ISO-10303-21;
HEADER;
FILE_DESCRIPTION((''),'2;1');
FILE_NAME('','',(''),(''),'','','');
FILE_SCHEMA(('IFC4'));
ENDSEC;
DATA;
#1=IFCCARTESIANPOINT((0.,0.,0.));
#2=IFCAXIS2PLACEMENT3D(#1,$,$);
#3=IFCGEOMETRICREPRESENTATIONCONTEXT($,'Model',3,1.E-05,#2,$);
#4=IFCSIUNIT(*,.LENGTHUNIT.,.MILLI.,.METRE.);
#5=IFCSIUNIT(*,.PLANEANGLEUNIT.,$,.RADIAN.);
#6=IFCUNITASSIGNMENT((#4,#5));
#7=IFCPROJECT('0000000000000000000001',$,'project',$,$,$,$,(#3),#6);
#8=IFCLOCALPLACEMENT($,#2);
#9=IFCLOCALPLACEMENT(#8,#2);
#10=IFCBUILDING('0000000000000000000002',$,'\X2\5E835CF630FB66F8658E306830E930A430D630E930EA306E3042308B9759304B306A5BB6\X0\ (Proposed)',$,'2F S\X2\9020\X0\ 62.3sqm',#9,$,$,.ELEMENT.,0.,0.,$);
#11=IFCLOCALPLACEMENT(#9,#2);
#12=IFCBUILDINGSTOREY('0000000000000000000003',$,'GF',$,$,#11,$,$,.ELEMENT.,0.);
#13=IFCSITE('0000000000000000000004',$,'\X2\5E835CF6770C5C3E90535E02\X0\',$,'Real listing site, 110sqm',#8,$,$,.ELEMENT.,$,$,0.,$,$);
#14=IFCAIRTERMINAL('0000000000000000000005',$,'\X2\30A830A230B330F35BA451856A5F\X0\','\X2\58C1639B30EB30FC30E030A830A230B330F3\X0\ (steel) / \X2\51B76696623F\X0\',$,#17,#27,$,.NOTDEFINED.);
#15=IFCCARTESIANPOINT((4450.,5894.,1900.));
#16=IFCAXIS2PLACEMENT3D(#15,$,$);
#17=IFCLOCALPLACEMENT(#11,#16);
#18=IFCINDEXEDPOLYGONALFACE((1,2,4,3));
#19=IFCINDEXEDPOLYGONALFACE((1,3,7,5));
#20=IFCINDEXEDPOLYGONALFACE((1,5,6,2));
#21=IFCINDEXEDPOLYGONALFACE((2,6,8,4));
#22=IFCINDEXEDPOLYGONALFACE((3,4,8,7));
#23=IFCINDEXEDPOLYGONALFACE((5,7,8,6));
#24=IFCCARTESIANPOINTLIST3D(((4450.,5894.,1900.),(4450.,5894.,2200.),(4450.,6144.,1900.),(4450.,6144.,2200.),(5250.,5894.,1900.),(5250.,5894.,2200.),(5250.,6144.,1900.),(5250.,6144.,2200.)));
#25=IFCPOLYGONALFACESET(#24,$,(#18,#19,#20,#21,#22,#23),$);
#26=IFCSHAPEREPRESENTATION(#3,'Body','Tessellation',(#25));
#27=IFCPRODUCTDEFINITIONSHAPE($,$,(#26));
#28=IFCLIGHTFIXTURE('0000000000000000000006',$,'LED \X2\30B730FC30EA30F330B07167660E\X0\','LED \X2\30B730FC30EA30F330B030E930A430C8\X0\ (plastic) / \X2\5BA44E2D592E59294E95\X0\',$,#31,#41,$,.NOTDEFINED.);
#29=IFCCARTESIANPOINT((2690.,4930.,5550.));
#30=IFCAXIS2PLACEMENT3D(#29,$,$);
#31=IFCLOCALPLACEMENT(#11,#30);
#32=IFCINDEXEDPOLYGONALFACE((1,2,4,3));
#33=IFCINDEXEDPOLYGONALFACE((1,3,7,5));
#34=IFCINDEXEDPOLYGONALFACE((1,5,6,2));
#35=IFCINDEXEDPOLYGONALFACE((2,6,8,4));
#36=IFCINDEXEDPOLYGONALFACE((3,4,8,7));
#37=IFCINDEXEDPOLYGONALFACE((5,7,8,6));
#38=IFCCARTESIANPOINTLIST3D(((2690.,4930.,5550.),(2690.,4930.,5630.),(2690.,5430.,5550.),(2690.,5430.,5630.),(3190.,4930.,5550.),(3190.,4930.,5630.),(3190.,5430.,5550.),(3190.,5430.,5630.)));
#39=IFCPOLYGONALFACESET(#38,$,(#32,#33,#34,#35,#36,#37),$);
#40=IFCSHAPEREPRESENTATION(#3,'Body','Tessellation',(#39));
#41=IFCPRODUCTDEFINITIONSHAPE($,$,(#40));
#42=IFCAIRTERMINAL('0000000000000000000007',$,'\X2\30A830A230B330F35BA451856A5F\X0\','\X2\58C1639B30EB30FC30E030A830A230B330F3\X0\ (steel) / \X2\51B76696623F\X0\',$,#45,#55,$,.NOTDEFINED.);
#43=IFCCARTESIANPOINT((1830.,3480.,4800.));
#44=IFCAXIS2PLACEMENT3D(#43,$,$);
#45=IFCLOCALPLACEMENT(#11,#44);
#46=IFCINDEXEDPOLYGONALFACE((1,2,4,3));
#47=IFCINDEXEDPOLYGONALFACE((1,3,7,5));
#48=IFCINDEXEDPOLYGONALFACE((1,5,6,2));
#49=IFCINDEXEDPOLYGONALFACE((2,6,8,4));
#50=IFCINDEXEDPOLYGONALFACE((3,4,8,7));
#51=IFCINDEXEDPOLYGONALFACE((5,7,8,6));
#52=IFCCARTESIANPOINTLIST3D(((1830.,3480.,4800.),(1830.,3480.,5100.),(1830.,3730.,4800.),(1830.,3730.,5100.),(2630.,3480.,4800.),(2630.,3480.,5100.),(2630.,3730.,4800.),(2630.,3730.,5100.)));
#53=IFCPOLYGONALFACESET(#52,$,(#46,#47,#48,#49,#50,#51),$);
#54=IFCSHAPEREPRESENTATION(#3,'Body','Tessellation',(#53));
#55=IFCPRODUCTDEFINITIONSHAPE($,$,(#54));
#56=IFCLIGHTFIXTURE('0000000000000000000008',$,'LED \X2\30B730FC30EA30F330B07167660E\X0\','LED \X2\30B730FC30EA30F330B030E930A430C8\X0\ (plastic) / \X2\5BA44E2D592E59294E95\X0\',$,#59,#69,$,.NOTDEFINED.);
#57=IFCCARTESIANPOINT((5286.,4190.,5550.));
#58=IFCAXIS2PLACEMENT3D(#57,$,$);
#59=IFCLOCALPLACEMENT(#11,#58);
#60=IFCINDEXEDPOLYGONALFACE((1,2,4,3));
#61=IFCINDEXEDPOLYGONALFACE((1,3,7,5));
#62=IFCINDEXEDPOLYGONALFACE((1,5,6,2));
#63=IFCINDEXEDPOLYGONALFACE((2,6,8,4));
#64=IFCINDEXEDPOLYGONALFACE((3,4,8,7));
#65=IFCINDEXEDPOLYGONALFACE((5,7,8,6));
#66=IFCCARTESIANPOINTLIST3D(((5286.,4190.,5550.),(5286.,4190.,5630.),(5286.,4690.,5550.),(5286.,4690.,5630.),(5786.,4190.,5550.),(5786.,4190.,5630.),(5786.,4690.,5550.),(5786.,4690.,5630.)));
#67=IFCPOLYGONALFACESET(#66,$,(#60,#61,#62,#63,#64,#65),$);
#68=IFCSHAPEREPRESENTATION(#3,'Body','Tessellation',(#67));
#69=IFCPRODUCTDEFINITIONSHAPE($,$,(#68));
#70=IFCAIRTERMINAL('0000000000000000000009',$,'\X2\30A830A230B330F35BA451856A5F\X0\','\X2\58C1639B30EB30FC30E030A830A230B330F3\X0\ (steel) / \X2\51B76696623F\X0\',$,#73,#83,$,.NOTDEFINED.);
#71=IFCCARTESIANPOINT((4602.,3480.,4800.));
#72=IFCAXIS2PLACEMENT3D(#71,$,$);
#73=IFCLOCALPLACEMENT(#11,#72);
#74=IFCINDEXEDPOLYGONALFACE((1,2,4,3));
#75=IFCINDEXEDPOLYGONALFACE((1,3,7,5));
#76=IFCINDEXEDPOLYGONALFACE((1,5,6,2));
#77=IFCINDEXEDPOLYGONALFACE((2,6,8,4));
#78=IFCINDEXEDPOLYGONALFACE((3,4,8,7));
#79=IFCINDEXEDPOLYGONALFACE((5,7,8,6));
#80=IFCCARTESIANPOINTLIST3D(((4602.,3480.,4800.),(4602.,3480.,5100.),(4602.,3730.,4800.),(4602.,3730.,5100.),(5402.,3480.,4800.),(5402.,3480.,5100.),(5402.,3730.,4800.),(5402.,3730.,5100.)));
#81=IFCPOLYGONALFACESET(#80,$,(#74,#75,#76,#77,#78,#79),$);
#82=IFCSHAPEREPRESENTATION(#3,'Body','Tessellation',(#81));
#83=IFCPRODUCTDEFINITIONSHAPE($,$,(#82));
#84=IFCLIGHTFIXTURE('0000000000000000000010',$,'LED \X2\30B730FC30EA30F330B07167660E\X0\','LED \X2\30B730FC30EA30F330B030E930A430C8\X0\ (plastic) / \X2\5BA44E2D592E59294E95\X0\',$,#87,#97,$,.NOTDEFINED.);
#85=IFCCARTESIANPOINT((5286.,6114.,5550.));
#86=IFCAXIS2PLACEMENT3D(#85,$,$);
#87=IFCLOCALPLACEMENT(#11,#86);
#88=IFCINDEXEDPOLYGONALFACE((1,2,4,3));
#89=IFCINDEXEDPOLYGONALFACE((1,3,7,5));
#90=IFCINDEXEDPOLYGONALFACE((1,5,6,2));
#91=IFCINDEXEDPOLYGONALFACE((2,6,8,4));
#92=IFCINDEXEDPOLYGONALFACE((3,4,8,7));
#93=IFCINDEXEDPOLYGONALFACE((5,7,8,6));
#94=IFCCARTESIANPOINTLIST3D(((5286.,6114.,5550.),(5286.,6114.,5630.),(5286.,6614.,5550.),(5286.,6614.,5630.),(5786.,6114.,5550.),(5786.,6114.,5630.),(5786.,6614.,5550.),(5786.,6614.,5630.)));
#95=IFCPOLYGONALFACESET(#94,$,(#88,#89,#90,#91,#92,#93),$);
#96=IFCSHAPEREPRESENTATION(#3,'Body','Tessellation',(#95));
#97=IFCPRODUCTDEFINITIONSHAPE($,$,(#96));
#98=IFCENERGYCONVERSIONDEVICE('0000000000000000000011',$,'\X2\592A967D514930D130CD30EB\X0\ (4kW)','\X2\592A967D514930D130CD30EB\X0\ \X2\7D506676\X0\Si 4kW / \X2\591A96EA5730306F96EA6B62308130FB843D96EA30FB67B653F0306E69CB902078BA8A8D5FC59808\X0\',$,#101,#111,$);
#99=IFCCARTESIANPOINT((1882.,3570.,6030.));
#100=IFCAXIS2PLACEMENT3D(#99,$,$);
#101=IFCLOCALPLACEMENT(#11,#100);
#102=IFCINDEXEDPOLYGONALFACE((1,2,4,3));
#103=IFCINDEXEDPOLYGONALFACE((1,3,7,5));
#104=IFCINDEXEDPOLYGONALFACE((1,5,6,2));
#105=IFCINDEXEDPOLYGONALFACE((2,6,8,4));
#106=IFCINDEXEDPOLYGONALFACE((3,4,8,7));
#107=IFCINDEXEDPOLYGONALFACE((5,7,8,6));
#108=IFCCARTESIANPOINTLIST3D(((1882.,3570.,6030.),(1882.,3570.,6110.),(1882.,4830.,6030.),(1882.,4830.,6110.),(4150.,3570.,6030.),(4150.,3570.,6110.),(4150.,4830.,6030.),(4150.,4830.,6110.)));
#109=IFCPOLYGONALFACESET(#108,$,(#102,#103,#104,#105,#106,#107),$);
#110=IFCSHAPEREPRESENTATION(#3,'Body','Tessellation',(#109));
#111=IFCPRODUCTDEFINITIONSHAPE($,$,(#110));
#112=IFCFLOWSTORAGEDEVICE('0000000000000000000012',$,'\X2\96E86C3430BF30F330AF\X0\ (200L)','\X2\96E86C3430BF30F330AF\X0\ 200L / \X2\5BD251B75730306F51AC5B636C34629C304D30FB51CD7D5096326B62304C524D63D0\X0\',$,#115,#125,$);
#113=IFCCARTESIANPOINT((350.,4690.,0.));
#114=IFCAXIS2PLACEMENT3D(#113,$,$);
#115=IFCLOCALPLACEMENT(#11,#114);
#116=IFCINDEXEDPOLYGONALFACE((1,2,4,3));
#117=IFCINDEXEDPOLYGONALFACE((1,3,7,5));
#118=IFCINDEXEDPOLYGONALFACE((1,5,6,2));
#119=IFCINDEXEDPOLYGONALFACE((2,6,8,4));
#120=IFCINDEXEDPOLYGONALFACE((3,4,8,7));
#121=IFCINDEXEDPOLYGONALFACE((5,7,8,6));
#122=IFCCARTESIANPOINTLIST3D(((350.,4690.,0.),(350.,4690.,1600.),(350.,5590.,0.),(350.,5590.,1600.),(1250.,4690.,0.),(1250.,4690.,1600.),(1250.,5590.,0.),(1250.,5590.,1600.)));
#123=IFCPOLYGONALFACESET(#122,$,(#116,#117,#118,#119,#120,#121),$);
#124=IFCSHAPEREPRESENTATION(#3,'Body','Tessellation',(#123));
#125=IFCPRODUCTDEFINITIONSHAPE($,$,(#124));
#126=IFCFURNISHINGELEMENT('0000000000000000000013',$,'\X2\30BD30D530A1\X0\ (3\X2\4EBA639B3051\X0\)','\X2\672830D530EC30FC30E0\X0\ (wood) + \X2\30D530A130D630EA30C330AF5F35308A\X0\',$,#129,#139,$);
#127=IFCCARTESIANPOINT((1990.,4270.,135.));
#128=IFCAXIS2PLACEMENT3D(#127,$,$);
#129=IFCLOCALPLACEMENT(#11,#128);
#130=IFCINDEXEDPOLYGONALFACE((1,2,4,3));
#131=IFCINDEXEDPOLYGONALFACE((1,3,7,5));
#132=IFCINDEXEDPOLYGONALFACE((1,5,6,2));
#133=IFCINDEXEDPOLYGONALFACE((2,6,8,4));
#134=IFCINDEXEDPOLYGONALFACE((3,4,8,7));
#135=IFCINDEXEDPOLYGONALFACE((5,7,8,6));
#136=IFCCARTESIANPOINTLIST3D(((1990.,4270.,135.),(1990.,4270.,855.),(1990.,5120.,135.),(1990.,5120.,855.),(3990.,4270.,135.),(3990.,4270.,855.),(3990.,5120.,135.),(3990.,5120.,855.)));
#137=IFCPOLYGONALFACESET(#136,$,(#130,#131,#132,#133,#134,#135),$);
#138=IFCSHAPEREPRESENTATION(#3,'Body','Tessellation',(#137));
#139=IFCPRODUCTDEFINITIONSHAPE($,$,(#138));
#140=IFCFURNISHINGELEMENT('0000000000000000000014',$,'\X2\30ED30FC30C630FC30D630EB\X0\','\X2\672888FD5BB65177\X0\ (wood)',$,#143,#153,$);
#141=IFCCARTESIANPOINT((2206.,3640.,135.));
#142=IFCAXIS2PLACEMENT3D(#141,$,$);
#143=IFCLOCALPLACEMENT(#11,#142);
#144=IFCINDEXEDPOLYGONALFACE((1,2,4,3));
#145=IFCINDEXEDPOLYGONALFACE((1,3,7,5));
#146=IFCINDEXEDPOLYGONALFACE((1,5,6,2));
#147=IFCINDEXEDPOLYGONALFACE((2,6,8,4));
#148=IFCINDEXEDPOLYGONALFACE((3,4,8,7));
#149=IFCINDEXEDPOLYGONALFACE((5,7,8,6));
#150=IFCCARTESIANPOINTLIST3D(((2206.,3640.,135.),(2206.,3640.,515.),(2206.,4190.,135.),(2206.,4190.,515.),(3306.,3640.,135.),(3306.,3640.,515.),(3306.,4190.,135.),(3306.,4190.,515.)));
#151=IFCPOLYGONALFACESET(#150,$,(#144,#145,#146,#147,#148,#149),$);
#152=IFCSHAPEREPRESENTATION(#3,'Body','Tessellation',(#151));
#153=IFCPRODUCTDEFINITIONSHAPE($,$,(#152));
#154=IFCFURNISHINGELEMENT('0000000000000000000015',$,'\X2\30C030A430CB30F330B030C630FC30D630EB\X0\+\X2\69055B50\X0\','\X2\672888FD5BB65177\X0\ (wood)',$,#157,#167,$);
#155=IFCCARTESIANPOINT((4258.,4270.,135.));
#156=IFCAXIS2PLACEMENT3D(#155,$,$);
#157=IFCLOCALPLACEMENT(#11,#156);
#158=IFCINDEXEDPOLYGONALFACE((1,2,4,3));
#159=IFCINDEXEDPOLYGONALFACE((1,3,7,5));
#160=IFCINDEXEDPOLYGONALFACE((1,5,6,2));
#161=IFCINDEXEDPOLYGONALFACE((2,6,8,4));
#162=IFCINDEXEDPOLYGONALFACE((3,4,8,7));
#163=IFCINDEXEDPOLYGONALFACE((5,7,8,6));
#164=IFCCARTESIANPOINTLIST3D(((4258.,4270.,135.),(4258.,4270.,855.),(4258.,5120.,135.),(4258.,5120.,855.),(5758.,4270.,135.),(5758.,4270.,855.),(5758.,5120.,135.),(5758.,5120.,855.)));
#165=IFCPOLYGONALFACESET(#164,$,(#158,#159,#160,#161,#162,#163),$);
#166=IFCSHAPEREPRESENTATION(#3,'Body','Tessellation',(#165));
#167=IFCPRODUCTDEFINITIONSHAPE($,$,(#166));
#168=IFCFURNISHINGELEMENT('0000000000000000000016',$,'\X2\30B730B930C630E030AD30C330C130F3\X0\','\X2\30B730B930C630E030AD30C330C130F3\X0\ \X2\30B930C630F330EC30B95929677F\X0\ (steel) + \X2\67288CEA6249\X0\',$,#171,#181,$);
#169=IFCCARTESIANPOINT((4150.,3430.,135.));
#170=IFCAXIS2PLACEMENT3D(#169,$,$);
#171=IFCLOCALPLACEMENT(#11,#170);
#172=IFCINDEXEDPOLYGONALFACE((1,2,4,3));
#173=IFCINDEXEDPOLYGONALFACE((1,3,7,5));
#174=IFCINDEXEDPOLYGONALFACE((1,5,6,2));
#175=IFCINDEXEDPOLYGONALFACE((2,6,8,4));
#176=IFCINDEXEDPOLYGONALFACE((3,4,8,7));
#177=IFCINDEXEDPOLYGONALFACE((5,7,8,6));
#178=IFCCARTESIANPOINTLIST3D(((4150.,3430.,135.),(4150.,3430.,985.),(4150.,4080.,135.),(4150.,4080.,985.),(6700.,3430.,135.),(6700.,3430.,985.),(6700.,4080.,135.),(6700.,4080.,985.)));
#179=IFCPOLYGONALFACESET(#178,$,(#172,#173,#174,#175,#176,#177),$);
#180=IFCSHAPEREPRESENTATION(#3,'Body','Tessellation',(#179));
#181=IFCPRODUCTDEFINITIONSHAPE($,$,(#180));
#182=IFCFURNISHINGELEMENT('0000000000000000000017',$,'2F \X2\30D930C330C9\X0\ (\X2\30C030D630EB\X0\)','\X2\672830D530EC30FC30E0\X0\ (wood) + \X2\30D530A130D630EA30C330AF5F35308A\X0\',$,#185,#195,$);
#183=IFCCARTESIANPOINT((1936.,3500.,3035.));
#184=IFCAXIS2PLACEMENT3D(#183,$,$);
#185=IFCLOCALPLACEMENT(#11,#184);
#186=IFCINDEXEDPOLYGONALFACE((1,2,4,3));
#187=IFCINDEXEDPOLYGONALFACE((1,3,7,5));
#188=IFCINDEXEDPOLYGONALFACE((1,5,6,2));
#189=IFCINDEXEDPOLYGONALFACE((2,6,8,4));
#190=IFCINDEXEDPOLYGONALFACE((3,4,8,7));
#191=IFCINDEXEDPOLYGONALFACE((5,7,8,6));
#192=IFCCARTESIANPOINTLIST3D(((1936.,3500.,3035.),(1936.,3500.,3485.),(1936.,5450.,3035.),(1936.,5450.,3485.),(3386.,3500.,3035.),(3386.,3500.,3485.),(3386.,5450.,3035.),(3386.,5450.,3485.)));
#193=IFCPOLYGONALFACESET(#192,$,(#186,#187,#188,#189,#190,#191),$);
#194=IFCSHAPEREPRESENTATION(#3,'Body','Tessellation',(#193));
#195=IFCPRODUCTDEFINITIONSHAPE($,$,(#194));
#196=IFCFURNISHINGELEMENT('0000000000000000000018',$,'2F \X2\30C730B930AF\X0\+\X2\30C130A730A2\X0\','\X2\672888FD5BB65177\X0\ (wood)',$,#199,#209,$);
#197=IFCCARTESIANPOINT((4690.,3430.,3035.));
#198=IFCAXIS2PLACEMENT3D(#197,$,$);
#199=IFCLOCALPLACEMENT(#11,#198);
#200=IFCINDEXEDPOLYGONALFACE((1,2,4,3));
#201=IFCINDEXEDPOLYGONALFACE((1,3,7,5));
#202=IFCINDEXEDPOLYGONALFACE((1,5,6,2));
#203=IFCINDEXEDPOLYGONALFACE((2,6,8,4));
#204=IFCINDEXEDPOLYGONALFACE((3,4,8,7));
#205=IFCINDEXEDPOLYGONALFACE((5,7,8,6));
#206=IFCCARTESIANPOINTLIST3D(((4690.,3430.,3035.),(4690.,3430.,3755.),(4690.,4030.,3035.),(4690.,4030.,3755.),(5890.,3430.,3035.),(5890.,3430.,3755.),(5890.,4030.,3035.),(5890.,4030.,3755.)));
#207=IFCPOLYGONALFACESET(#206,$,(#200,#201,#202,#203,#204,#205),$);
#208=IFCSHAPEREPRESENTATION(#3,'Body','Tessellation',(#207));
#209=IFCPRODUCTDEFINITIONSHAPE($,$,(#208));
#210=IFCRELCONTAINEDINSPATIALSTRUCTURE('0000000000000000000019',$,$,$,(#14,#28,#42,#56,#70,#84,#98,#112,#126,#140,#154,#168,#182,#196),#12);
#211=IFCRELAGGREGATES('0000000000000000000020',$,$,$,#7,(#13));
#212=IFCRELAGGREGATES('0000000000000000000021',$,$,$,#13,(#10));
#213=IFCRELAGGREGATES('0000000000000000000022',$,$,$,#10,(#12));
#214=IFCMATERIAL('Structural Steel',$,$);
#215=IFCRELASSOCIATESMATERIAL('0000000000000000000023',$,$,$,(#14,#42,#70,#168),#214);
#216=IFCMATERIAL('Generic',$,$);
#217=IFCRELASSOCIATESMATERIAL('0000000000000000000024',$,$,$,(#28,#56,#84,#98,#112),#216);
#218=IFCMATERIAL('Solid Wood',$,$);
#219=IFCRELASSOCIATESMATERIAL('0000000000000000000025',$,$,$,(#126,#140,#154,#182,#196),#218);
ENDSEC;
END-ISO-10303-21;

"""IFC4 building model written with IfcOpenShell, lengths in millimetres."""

from ifc_helpers import new_model, si_unit, frame, frame_2d, origin, place, context, project, spatial, rectangle, extrude, material, element, save


model = new_model("IFC4")

# Units and contexts
model_context = context("Model", 3, precision=1e-05, world=origin())
ifc_project = project(units=[si_unit("LENGTHUNIT", "METRE", prefix="MILLI"), si_unit("PLANEANGLEUNIT", "RADIAN")], contexts=[model_context])

# Site, building, storey
site_placement = place(None, origin())
site = spatial("IfcSite", under=ifc_project, at=site_placement, Name="広島県尾道市", ObjectType="Real listing site, 110sqm", CompositionType="ELEMENT", RefElevation=0.0)
building_placement = place(site_placement, origin())
building = spatial("IfcBuilding", under=site, at=building_placement, Name="広島・書斎とライブラリのある静かな家 (Proposed)", ObjectType="2F S造 62.3sqm", CompositionType="ELEMENT", ElevationOfRefHeight=0.0, ElevationOfTerrain=0.0)
storey_placement = place(building_placement, origin())
storey = spatial("IfcBuildingStorey", under=building, at=storey_placement, Name="GF", CompositionType="ELEMENT", Elevation=0.0)

# Shared definitions
ifc_material_1 = material(Name="Solid Wood")

# Shared definitions
ifc_material_2 = material(Name="Structural Steel")

# Shared definitions
ifc_material_3 = material(Name="Generic")

# Air terminal
air_terminal_1_placement = place(storey_placement, frame((4450.0, 5894.0, 1900.0)))
element("IfcAirTerminal", 1, at=air_terminal_1_placement, inside=storey, material=ifc_material_2, Name="エアコン室内機", Description="壁掛ルームエアコン (steel) / 冷暖房", PredefinedType="NOTDEFINED", context=model_context, shape_type="SweptSolid", body=[
    extrude(rectangle(XDim=800.0, YDim=250.0, at=frame_2d((400.0, 125.0))), frame((4450.0, 5894.0, 1900.0)), (0.0, 0.0, 1.0), 300.0),
])

# Light fixture
light_fixture_1_placement = place(storey_placement, frame((2690.0, 4930.0, 5550.0)))
element("IfcLightFixture", 2, at=light_fixture_1_placement, inside=storey, material=ifc_material_3, Name="LED シーリング照明", Description="LED シーリングライト (plastic) / 室中央天井", PredefinedType="NOTDEFINED", context=model_context, shape_type="SweptSolid", body=[
    extrude(rectangle(XDim=500.0, YDim=500.0, at=frame_2d((250.0, 250.0))), frame((2690.0, 4930.0, 5550.0)), (0.0, 0.0, 1.0), 80.0),
])

# Air terminal
air_terminal_2_placement = place(storey_placement, frame((1830.0, 3480.0, 4800.0)))
element("IfcAirTerminal", 3, at=air_terminal_2_placement, inside=storey, material=ifc_material_2, Name="エアコン室内機", Description="壁掛ルームエアコン (steel) / 冷暖房", PredefinedType="NOTDEFINED", context=model_context, shape_type="SweptSolid", body=[
    extrude(rectangle(XDim=800.0, YDim=250.0, at=frame_2d((400.0, 125.0))), frame((1830.0, 3480.0, 4800.0)), (0.0, 0.0, 1.0), 300.0),
])

# Light fixture
light_fixture_2_placement = place(storey_placement, frame((5286.0, 4190.0, 5550.0)))
element("IfcLightFixture", 4, at=light_fixture_2_placement, inside=storey, material=ifc_material_3, Name="LED シーリング照明", Description="LED シーリングライト (plastic) / 室中央天井", PredefinedType="NOTDEFINED", context=model_context, shape_type="SweptSolid", body=[
    extrude(rectangle(XDim=500.0, YDim=500.0, at=frame_2d((250.0, 250.0))), frame((5286.0, 4190.0, 5550.0)), (0.0, 0.0, 1.0), 80.0),
])

# Air terminal
air_terminal_3_placement = place(storey_placement, frame((4602.0, 3480.0, 4800.0)))
element("IfcAirTerminal", 5, at=air_terminal_3_placement, inside=storey, material=ifc_material_2, Name="エアコン室内機", Description="壁掛ルームエアコン (steel) / 冷暖房", PredefinedType="NOTDEFINED", context=model_context, shape_type="SweptSolid", body=[
    extrude(rectangle(XDim=800.0, YDim=250.0, at=frame_2d((400.0, 125.0))), frame((4602.0, 3480.0, 4800.0)), (0.0, 0.0, 1.0), 300.0),
])

# Light fixture
light_fixture_3_placement = place(storey_placement, frame((5286.0, 6114.0, 5550.0)))
element("IfcLightFixture", 6, at=light_fixture_3_placement, inside=storey, material=ifc_material_3, Name="LED シーリング照明", Description="LED シーリングライト (plastic) / 室中央天井", PredefinedType="NOTDEFINED", context=model_context, shape_type="SweptSolid", body=[
    extrude(rectangle(XDim=500.0, YDim=500.0, at=frame_2d((250.0, 250.0))), frame((5286.0, 6114.0, 5550.0)), (0.0, 0.0, 1.0), 80.0),
])

# Energy conversion device
energy_conversion_device_placement = place(storey_placement, frame((1882.0, 3570.0, 6030.0)))
element("IfcEnergyConversionDevice", 7, at=energy_conversion_device_placement, inside=storey, material=ifc_material_3, Name="太陽光パネル (4kW)", Description="太陽光パネル 結晶Si 4kW / 多雪地は雪止め・落雪・架台の構造確認必須", context=model_context, shape_type="SweptSolid", body=[
    extrude(rectangle(XDim=2268.0, YDim=1260.0, at=frame_2d((1134.0, 630.0))), frame((1882.0, 3570.0, 6030.0)), (0.0, 0.0, 1.0), 80.0),
])

# Flow storage device
flow_storage_device_1_placement = place(storey_placement, frame((350.0, 4690.0, 0.0)))
element("IfcFlowStorageDevice", 8, at=flow_storage_device_1_placement, inside=storey, material=ifc_material_3, Name="雨水タンク (200L)", Description="雨水タンク 200L / 寒冷地は冬季水抜き・凍結防止が前提", context=model_context, shape_type="SweptSolid", body=[
    extrude(rectangle(XDim=900.0, YDim=900.0, at=frame_2d((450.0, 450.0))), frame((350.0, 4690.0, 0.0)), (0.0, 0.0, 1.0), 1600.0),
])

# Furnishing elements
furnishing_1_placement = place(storey_placement, frame((1990.0, 4270.0, 135.0)))
element("IfcFurnishingElement", 9, at=furnishing_1_placement, inside=storey, material=ifc_material_1, Name="ソファ (3人掛け)", Description="木フレーム (wood) + ファブリック張り", context=model_context, shape_type="SweptSolid", body=[
    extrude(rectangle(XDim=2000.0, YDim=850.0, at=frame_2d((1000.0, 425.0))), frame((1990.0, 4270.0, 135.0)), (0.0, 0.0, 1.0), 720.0),
])
furnishing_2_placement = place(storey_placement, frame((2206.0, 3640.0, 135.0)))
element("IfcFurnishingElement", 10, at=furnishing_2_placement, inside=storey, material=ifc_material_1, Name="ローテーブル", Description="木製家具 (wood)", context=model_context, shape_type="SweptSolid", body=[
    extrude(rectangle(XDim=1100.0, YDim=550.0, at=frame_2d((550.0, 275.0))), frame((2206.0, 3640.0, 135.0)), (0.0, 0.0, 1.0), 380.0),
])
furnishing_3_placement = place(storey_placement, frame((4258.0, 4270.0, 135.0)))
element("IfcFurnishingElement", 11, at=furnishing_3_placement, inside=storey, material=ifc_material_1, Name="ダイニングテーブル+椅子", Description="木製家具 (wood)", context=model_context, shape_type="SweptSolid", body=[
    extrude(rectangle(XDim=1500.0, YDim=850.0, at=frame_2d((750.0, 425.0))), frame((4258.0, 4270.0, 135.0)), (0.0, 0.0, 1.0), 720.0),
])
furnishing_4_placement = place(storey_placement, frame((4150.0, 3430.0, 135.0)))
element("IfcFurnishingElement", 12, at=furnishing_4_placement, inside=storey, material=ifc_material_2, Name="システムキッチン", Description="システムキッチン ステンレス天板 (steel) + 木質扉", context=model_context, shape_type="SweptSolid", body=[
    extrude(rectangle(XDim=2550.0, YDim=650.0, at=frame_2d((1275.0, 325.0))), frame((4150.0, 3430.0, 135.0)), (0.0, 0.0, 1.0), 850.0),
])
furnishing_5_placement = place(storey_placement, frame((1936.0, 3500.0, 3035.0)))
element("IfcFurnishingElement", 13, at=furnishing_5_placement, inside=storey, material=ifc_material_1, Name="2F ベッド (ダブル)", Description="木フレーム (wood) + ファブリック張り", context=model_context, shape_type="SweptSolid", body=[
    extrude(rectangle(XDim=1450.0, YDim=1950.0, at=frame_2d((725.0, 975.0))), frame((1936.0, 3500.0, 3035.0)), (0.0, 0.0, 1.0), 450.0),
])
furnishing_6_placement = place(storey_placement, frame((4690.0, 3430.0, 3035.0)))
element("IfcFurnishingElement", 14, at=furnishing_6_placement, inside=storey, material=ifc_material_1, Name="2F デスク+チェア", Description="木製家具 (wood)", context=model_context, shape_type="SweptSolid", body=[
    extrude(rectangle(XDim=1200.0, YDim=600.0, at=frame_2d((600.0, 300.0))), frame((4690.0, 3430.0, 3035.0)), (0.0, 0.0, 1.0), 720.0),
])

save(model, "model.ifc")
